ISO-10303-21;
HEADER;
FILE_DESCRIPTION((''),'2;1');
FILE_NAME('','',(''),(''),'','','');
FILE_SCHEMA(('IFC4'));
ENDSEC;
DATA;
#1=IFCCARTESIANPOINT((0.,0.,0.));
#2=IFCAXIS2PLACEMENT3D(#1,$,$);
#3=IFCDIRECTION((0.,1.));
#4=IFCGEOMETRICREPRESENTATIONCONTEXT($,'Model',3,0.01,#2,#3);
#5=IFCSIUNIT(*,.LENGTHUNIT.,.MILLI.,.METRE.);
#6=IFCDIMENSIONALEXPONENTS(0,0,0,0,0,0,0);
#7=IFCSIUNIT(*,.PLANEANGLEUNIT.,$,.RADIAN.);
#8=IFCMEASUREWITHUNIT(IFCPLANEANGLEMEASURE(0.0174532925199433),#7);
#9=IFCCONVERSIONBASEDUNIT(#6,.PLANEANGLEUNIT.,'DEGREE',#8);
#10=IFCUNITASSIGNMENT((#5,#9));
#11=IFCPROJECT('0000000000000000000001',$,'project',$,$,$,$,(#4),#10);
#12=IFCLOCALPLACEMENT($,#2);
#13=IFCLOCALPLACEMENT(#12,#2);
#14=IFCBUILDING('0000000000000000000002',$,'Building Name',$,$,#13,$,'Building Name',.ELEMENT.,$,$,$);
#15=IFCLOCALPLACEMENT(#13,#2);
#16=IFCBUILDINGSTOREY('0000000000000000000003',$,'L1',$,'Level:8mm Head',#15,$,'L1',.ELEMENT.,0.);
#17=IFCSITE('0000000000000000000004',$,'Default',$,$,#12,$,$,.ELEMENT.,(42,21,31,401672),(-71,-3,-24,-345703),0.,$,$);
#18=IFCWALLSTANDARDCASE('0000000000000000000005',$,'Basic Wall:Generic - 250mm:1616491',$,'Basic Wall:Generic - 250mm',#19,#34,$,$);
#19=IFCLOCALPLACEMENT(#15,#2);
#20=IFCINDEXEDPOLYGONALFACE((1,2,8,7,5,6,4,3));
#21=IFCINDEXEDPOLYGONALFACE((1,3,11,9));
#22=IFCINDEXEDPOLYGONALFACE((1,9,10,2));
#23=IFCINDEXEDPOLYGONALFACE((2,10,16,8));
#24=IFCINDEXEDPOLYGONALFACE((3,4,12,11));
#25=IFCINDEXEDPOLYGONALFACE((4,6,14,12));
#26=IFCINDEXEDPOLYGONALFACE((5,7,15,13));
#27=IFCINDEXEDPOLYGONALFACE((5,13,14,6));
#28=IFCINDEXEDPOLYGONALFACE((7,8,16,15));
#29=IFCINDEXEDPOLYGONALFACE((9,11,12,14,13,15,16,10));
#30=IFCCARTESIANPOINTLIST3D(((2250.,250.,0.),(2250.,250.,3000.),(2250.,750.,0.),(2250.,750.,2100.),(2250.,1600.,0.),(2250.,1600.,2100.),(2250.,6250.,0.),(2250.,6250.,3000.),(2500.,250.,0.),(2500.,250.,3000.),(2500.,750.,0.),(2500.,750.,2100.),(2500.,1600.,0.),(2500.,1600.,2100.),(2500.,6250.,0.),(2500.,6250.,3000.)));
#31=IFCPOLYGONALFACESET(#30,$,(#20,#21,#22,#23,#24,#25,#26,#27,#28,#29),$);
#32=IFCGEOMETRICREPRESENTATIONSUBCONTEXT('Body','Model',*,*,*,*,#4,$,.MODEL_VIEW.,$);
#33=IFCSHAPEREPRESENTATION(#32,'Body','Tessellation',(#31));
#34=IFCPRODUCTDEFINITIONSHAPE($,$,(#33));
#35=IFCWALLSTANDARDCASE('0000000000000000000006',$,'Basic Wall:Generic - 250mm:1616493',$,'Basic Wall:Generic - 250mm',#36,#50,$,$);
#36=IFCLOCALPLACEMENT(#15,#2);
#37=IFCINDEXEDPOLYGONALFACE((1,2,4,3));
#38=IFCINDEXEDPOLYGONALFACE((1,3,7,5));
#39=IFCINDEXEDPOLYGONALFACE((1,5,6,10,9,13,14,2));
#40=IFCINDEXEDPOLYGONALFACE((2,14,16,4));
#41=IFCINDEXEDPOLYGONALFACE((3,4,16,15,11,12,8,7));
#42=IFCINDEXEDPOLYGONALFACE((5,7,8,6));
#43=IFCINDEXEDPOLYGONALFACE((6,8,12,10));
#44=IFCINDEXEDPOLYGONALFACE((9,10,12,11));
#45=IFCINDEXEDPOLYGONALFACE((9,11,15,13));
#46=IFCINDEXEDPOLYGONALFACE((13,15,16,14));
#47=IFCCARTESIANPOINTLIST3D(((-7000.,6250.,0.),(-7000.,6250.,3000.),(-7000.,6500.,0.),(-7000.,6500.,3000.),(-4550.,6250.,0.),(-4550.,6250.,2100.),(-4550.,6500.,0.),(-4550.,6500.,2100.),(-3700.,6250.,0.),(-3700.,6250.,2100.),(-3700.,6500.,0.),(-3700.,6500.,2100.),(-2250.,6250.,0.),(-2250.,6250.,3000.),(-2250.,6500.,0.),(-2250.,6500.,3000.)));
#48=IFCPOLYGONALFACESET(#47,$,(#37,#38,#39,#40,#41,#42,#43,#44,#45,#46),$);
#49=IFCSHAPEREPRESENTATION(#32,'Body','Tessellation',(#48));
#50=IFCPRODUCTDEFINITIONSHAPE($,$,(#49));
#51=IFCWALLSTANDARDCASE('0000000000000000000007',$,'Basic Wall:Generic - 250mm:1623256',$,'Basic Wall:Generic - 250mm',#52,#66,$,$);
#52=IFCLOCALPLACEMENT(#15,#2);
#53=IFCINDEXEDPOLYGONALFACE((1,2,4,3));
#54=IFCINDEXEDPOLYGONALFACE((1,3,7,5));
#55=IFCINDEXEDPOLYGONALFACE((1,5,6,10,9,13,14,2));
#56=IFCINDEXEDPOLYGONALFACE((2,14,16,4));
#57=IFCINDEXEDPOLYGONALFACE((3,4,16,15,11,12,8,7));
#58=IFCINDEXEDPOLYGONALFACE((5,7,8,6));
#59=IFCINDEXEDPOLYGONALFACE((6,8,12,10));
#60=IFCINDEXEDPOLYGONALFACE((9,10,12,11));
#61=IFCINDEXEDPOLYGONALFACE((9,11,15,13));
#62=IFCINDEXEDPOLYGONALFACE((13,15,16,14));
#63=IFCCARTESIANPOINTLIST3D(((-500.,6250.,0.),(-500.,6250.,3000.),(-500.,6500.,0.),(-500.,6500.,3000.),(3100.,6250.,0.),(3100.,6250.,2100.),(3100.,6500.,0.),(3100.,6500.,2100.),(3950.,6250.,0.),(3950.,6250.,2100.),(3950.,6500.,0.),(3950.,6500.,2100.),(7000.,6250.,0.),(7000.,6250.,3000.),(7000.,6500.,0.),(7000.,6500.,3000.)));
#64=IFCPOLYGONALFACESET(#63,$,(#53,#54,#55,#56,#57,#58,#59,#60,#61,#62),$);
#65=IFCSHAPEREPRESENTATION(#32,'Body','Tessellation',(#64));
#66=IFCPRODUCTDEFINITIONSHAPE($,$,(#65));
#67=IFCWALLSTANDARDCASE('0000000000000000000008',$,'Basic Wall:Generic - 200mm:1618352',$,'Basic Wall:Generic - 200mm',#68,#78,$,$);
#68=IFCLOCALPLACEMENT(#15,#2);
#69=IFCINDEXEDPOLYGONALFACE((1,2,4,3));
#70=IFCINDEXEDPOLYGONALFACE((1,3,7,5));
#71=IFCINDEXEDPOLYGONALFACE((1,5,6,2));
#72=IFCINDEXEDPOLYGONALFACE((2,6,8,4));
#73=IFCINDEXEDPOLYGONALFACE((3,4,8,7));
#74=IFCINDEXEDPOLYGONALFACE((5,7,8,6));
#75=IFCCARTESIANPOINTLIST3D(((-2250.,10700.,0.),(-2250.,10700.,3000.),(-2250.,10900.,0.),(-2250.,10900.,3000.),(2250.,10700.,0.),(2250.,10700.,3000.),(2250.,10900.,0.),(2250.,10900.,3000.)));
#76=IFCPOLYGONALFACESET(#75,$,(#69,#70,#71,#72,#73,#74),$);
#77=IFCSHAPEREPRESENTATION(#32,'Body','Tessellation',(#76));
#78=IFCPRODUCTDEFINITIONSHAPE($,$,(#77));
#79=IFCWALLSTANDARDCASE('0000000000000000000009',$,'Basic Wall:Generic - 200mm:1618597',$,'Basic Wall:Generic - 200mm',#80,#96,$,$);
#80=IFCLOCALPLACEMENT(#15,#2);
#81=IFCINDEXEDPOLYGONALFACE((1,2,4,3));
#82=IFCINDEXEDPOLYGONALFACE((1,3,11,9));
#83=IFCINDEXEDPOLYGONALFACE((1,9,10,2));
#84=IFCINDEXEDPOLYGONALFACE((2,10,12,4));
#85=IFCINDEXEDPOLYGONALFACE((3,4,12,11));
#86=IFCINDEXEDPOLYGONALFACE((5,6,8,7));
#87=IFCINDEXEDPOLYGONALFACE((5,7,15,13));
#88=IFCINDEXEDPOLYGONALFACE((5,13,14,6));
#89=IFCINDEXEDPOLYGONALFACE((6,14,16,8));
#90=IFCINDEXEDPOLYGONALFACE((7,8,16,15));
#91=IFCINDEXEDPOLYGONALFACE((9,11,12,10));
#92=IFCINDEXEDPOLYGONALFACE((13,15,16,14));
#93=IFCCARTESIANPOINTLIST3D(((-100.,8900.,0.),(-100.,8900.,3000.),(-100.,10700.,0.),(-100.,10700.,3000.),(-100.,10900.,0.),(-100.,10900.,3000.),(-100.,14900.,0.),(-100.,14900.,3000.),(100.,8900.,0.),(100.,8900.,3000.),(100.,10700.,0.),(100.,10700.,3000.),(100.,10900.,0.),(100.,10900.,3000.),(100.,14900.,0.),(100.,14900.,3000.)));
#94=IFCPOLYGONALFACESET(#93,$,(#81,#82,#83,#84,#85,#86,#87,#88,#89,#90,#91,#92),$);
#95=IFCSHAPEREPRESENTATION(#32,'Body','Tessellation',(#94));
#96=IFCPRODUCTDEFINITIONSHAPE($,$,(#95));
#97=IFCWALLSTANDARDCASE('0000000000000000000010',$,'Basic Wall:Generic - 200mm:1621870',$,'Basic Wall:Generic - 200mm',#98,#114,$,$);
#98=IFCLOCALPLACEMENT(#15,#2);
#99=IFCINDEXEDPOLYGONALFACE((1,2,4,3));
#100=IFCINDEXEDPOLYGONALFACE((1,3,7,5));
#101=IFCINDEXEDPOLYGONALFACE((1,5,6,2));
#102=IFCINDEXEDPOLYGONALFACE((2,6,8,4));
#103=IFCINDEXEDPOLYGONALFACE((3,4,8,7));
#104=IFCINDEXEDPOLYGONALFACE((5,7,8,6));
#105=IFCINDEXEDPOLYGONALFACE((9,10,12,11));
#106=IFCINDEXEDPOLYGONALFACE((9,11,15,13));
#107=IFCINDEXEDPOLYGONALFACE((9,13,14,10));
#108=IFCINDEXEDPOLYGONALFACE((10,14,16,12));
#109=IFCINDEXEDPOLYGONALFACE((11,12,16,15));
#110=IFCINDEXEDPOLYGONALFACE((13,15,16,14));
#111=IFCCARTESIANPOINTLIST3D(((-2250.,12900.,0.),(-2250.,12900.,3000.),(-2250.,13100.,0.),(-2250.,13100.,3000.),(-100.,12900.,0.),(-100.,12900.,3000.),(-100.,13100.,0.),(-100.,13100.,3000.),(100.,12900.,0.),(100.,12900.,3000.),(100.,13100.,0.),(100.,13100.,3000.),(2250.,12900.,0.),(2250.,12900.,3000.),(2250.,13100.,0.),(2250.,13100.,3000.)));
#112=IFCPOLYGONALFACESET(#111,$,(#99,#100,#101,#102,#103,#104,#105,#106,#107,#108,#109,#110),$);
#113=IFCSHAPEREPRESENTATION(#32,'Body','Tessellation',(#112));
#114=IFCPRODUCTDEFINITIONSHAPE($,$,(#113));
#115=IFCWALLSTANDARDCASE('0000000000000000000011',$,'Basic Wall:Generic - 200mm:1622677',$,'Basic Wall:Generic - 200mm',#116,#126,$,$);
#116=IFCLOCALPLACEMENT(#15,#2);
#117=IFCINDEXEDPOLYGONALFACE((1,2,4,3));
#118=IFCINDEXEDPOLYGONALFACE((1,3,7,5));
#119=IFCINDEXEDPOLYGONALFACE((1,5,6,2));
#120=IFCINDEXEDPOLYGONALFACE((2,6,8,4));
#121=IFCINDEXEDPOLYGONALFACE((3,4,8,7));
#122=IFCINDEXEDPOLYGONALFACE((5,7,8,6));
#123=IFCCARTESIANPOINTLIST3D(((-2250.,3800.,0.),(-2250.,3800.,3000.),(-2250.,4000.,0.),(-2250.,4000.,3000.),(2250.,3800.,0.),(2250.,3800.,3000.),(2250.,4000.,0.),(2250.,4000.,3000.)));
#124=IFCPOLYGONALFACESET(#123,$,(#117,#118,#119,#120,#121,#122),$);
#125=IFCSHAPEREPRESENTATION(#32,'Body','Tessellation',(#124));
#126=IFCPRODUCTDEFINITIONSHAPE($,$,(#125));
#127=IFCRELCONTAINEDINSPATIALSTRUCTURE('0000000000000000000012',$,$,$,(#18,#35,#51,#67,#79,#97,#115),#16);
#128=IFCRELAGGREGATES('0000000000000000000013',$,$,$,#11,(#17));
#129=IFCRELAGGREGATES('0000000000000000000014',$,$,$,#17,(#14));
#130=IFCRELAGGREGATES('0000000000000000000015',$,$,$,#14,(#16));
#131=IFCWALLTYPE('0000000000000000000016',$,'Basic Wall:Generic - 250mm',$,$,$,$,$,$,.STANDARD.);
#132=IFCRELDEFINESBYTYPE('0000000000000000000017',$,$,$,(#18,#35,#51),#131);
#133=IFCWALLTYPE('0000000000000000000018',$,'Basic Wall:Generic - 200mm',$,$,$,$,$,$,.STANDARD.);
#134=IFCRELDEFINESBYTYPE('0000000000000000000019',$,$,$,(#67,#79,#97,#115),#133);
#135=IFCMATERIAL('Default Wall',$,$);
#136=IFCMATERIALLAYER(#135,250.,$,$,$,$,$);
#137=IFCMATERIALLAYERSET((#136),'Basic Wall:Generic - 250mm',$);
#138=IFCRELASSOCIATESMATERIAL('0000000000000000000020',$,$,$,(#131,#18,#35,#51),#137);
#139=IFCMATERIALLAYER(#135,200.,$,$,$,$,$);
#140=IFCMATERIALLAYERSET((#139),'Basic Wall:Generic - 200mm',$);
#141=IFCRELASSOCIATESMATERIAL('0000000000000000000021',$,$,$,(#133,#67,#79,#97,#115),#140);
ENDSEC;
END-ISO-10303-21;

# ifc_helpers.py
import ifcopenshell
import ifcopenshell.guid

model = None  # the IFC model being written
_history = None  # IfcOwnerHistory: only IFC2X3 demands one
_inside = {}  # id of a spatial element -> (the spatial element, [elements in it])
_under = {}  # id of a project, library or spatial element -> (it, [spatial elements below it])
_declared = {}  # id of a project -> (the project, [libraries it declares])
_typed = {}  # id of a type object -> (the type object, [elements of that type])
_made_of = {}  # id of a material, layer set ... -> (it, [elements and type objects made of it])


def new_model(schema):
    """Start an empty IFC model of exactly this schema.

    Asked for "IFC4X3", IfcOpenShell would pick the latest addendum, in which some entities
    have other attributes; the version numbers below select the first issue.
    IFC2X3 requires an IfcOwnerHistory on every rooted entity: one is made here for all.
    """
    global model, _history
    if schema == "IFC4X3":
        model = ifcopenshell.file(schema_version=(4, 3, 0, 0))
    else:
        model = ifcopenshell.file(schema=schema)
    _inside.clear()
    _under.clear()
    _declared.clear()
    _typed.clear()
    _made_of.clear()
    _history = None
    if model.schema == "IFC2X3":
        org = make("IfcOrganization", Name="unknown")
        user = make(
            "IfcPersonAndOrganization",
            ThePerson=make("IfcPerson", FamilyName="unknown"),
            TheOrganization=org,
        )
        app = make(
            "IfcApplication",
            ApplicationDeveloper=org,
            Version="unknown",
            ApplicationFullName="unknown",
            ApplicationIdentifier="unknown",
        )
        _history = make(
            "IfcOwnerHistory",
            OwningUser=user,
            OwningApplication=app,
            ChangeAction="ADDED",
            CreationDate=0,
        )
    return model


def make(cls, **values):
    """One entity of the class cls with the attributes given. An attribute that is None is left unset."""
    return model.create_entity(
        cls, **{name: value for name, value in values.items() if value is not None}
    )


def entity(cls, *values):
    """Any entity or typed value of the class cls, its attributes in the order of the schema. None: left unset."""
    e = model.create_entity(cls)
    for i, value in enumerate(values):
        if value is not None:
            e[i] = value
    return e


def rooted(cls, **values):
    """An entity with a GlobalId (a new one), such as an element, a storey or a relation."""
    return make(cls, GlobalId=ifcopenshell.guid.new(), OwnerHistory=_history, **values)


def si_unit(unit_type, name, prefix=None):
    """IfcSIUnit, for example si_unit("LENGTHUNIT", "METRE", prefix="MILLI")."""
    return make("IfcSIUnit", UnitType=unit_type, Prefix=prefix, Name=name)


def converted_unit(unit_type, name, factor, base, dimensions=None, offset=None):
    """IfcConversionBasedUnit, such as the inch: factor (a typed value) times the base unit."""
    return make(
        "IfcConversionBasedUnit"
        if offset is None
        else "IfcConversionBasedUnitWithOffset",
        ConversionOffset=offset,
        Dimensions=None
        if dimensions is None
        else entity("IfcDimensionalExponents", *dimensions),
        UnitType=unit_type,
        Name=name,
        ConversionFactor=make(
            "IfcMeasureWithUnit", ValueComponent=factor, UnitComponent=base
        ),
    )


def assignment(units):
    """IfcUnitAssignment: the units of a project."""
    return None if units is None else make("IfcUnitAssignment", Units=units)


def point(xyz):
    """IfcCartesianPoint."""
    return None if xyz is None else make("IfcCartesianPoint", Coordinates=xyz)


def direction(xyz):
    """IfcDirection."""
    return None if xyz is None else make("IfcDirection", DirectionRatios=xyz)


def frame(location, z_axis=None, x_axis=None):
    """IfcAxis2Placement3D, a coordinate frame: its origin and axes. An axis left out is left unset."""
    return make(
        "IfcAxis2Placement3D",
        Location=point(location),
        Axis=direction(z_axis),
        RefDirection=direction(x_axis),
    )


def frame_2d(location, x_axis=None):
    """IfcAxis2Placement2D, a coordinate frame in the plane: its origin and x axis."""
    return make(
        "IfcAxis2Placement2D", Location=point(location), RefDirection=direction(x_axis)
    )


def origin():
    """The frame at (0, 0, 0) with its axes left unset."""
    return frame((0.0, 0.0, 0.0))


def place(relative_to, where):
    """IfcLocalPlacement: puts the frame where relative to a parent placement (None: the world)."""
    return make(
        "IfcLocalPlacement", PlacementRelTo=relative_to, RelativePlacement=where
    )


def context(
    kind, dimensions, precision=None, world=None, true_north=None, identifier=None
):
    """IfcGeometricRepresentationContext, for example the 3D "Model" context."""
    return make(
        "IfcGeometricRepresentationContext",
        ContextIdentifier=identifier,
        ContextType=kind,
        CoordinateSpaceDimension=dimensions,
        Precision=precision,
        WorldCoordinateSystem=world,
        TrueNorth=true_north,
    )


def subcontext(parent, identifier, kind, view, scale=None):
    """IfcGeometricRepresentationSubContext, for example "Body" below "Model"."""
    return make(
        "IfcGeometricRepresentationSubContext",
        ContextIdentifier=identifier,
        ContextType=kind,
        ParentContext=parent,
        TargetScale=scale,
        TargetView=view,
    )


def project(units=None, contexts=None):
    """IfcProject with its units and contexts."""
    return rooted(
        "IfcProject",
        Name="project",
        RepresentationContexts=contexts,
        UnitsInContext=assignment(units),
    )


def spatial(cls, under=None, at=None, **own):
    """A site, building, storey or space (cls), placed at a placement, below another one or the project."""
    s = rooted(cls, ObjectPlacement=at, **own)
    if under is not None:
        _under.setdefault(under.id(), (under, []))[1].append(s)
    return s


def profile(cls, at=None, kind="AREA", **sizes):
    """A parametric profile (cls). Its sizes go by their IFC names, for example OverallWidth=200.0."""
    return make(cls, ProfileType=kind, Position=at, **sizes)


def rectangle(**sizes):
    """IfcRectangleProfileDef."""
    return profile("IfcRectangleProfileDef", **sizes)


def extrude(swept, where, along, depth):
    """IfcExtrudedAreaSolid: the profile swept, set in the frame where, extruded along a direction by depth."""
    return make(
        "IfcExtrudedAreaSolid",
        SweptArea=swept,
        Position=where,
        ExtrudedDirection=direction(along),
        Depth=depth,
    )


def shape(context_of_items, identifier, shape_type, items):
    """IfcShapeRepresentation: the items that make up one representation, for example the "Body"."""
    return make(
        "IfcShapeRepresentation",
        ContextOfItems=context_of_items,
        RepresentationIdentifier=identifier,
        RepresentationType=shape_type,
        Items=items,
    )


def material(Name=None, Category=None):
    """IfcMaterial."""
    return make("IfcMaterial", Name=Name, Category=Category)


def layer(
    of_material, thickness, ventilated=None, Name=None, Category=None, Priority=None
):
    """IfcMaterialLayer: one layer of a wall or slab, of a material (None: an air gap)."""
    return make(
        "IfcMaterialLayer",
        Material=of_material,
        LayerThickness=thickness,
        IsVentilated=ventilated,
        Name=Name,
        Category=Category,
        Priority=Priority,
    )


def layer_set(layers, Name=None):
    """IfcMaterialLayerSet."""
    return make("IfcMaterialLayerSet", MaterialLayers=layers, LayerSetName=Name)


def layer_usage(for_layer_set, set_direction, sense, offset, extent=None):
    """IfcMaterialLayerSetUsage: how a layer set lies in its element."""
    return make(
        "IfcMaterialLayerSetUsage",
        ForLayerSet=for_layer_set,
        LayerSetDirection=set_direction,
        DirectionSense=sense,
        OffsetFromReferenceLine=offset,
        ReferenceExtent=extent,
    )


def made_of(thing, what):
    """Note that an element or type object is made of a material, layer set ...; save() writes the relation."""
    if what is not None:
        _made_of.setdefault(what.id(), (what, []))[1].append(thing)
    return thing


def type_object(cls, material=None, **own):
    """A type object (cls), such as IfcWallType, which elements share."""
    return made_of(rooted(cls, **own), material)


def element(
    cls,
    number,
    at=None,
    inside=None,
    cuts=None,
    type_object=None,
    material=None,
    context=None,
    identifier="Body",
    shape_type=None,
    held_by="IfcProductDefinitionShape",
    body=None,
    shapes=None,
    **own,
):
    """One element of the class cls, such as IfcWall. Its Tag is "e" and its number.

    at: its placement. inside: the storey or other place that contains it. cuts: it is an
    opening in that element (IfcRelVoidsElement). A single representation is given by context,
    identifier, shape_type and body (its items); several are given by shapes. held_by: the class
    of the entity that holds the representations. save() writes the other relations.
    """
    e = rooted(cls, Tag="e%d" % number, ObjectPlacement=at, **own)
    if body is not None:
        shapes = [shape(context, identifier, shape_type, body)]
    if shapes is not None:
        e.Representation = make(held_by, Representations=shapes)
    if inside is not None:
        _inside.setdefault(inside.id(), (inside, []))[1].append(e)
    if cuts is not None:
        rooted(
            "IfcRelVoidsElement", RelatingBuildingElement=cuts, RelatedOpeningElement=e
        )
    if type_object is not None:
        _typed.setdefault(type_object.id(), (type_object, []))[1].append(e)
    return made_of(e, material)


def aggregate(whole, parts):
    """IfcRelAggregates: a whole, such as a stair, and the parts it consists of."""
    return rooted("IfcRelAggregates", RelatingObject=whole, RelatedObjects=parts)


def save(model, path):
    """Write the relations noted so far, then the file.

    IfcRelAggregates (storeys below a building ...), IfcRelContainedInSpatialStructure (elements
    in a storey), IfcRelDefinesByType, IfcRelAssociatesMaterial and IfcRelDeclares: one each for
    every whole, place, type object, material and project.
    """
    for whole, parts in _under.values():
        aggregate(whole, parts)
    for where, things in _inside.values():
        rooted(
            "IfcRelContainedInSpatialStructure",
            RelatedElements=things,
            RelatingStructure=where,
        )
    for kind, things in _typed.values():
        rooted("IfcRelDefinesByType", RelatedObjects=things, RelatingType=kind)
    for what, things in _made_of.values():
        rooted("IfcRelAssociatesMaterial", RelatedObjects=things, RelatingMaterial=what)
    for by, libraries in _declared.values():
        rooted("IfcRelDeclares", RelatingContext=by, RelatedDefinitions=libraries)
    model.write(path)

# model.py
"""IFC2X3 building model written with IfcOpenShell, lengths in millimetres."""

from ifc_helpers import new_model, entity, si_unit, converted_unit, direction, frame, frame_2d, origin, place, context, subcontext, project, spatial, rectangle, extrude, material, layer, layer_set, layer_usage, type_object, element, save


model = new_model("IFC2X3")

# Units and contexts
model_context = context("Model", 3, precision=0.01, world=origin(), true_north=direction((0.0, 1.0)))
body_context = subcontext(model_context, "Body", "Model", "MODEL_VIEW")
ifc_project = project(units=[si_unit("LENGTHUNIT", "METRE", prefix="MILLI"), converted_unit("PLANEANGLEUNIT", "DEGREE", entity("IfcPlaneAngleMeasure", 0.0174532925199433), si_unit("PLANEANGLEUNIT", "RADIAN"), dimensions=[0, 0, 0, 0, 0, 0, 0])], contexts=[model_context])

# Site, building, storey
site_placement = place(None, origin())
site = spatial("IfcSite", under=ifc_project, at=site_placement, Name="Default", CompositionType="ELEMENT", RefLatitude=(42, 21, 31, 401672), RefLongitude=(-71, -3, -24, -345703), RefElevation=0.0)
building_placement = place(site_placement, origin())
building = spatial("IfcBuilding", under=site, at=building_placement, Name="Building Name", LongName="Building Name", CompositionType="ELEMENT")
storey_placement = place(building_placement, origin())
storey = spatial("IfcBuildingStorey", under=building, at=storey_placement, Name="L1", ObjectType="Level:8mm Head", LongName="L1", CompositionType="ELEMENT", Elevation=0.0)

# Shared definitions
ifc_material = material(Name="Default Wall")
ifc_layer_1 = layer(ifc_material, 250.0)
ifc_layer_set_1 = layer_set([ifc_layer_1], Name="Basic Wall:Generic - 250mm")
wall_type_1 = type_object("IfcWallType", Name="Basic Wall:Generic - 250mm", PredefinedType="STANDARD", material=ifc_layer_set_1)

# Walls, openings
ifc_layer_usage_1 = layer_usage(ifc_layer_set_1, "AXIS2", "NEGATIVE", 125.0)
wall_1_placement = place(storey_placement, frame((2375.0, 250.0, 0.0), z_axis=(0.0, 0.0, 1.0), x_axis=(0.0, 1.0, 0.0)))
wall_1 = element("IfcWallStandardCase", 1, at=wall_1_placement, inside=storey, type_object=wall_type_1, material=ifc_layer_usage_1, Name="Basic Wall:Generic - 250mm:1616491", ObjectType="Basic Wall:Generic - 250mm", context=body_context, shape_type="SweptSolid", body=[
    extrude(rectangle(XDim=6000.0, YDim=250.0, at=frame_2d((3000.0, 0.0), x_axis=(1.0, 0.0))), origin(), (0.0, 0.0, 1.0), 3000.0),
])
opening_1_placement = place(wall_1_placement, frame((500.0, -125.0, 0.0)))
element("IfcOpeningElement", 2, at=opening_1_placement, cuts=wall_1, ObjectType="Opening", context=body_context, shape_type="SweptSolid", body=[
    extrude(rectangle(XDim=2100.0, YDim=850.0, at=frame_2d((1050.0, 425.0), x_axis=(1.0, 0.0))), frame((0.0, 0.0, 0.0), z_axis=(0.0, 1.0, 0.0), x_axis=(0.0, 0.0, 1.0)), (0.0, 0.0, 1.0), 250.0),
])
ifc_layer_usage_2 = layer_usage(ifc_layer_set_1, "AXIS2", "NEGATIVE", 125.0)
wall_2_placement = place(storey_placement, frame((-7000.0, 6375.0, 0.0)))
wall_2 = element("IfcWallStandardCase", 3, at=wall_2_placement, inside=storey, type_object=wall_type_1, material=ifc_layer_usage_2, Name="Basic Wall:Generic - 250mm:1616493", ObjectType="Basic Wall:Generic - 250mm", context=body_context, shape_type="SweptSolid", body=[
    extrude(rectangle(XDim=4750.0, YDim=250.0, at=frame_2d((2375.0, 0.0), x_axis=(1.0, 0.0))), origin(), (0.0, 0.0, 1.0), 3000.0),
])
opening_2_placement = place(wall_2_placement, frame((3300.0, 125.0, 0.0)))
element("IfcOpeningElement", 4, at=opening_2_placement, cuts=wall_2, ObjectType="Opening", context=body_context, shape_type="SweptSolid", body=[
    extrude(rectangle(XDim=2100.0, YDim=850.0, at=frame_2d((1050.0, 425.0), x_axis=(1.0, 0.0))), frame((0.0, 0.0, 0.0), z_axis=(0.0, -1.0, 0.0), x_axis=(0.0, 0.0, 1.0)), (0.0, 0.0, 1.0), 250.0),
])

# Wall, openings
ifc_layer_usage_3 = layer_usage(ifc_layer_set_1, "AXIS2", "NEGATIVE", 125.0)
wall_3_placement = place(storey_placement, frame((-500.0, 6375.0, 0.0)))
wall_3 = element("IfcWallStandardCase", 5, at=wall_3_placement, inside=storey, type_object=wall_type_1, material=ifc_layer_usage_3, Name="Basic Wall:Generic - 250mm:1623256", ObjectType="Basic Wall:Generic - 250mm", context=body_context, shape_type="SweptSolid", body=[
    extrude(rectangle(XDim=7500.0, YDim=250.0, at=frame_2d((3750.0, 0.0), x_axis=(1.0, 0.0))), origin(), (0.0, 0.0, 1.0), 3000.0),
])
opening_3_placement = place(wall_3_placement, frame((4450.0, 125.0, 0.0)))
element("IfcOpeningElement", 6, at=opening_3_placement, cuts=wall_3, ObjectType="Opening", context=body_context, shape_type="SweptSolid", body=[
    extrude(rectangle(XDim=2100.0, YDim=850.0, at=frame_2d((1050.0, 425.0), x_axis=(1.0, 0.0))), frame((0.0, 0.0, 0.0), z_axis=(0.0, -1.0, 0.0), x_axis=(0.0, 0.0, 1.0)), (0.0, 0.0, 1.0), 250.0),
])
opening_4_placement = place(wall_3_placement, frame((500.0, -6375.0, 0.0)))
element("IfcOpeningElement", 7, at=opening_4_placement, cuts=wall_3, ObjectType="Opening", context=body_context, shape_type="SweptSolid", body=[
    extrude(rectangle(XDim=2100.0, YDim=850.0, at=frame_2d((0.0, 0.0), x_axis=(1.0, 0.0))), frame((3525.0, 4976.0, 1050.0), z_axis=(0.0, 1.0, 0.0), x_axis=(0.0, 0.0, 1.0)), (0.0, 0.0, 1.0), 3048.0),
])

# Wall
ifc_layer_2 = layer(ifc_material, 200.0)
ifc_layer_set_2 = layer_set([ifc_layer_2], Name="Basic Wall:Generic - 200mm")
ifc_layer_usage_4 = layer_usage(ifc_layer_set_2, "AXIS2", "NEGATIVE", 100.0)
wall_type_2 = type_object("IfcWallType", Name="Basic Wall:Generic - 200mm", PredefinedType="STANDARD", material=ifc_layer_set_2)
wall_4_placement = place(storey_placement, frame((-2250.0, 10800.0, 0.0)))
element("IfcWallStandardCase", 8, at=wall_4_placement, inside=storey, type_object=wall_type_2, material=ifc_layer_usage_4, Name="Basic Wall:Generic - 200mm:1618352", ObjectType="Basic Wall:Generic - 200mm", context=body_context, shape_type="SweptSolid", body=[
    extrude(rectangle(XDim=4500.0, YDim=200.0, at=frame_2d((2250.0, 0.0), x_axis=(-1.0, 0.0))), origin(), (0.0, 0.0, 1.0), 3000.0),
])

# Walls, openings
ifc_layer_usage_5 = layer_usage(ifc_layer_set_2, "AXIS2", "NEGATIVE", 100.0)
wall_5_placement = place(storey_placement, frame((0.0, 8900.0, 0.0), z_axis=(0.0, 0.0, 1.0), x_axis=(0.0, 1.0, 0.0)))
wall_5 = element("IfcWallStandardCase", 9, at=wall_5_placement, inside=storey, type_object=wall_type_2, material=ifc_layer_usage_5, Name="Basic Wall:Generic - 200mm:1618597", ObjectType="Basic Wall:Generic - 200mm", context=body_context, shape_type="SweptSolid", body=[
    extrude(rectangle(XDim=6000.0, YDim=200.0, at=frame_2d((3000.0, 0.0), x_axis=(-1.0, 0.0))), origin(), (0.0, 0.0, 1.0), 3000.0),
])
opening_5_placement = place(storey_placement, frame((0.0, 8900.0, 0.0), z_axis=(0.0, 0.0, 1.0), x_axis=(0.0, 1.0, 0.0)))
element("IfcOpeningElement", 10, at=opening_5_placement, cuts=wall_5, ObjectType="Opening", context=body_context, shape_type="SweptSolid", body=[
    extrude(rectangle(XDim=3000.0, YDim=200.0, at=frame_2d((0.0, 0.0), x_axis=(1.0, 0.0))), frame((1800.0, 0.0, 1500.0), z_axis=(1.0, 0.0, 0.0), x_axis=(0.0, 0.0, -1.0)), (0.0, 0.0, 1.0), 200.0),
])
ifc_layer_usage_6 = layer_usage(ifc_layer_set_2, "AXIS2", "NEGATIVE", 100.0)
wall_6_placement = place(storey_placement, frame((-2250.0, 13000.0, 0.0)))
wall_6 = element("IfcWallStandardCase", 11, at=wall_6_placement, inside=storey, type_object=wall_type_2, material=ifc_layer_usage_6, Name="Basic Wall:Generic - 200mm:1621870", ObjectType="Basic Wall:Generic - 200mm", context=body_context, shape_type="SweptSolid", body=[
    extrude(rectangle(XDim=4500.0, YDim=200.0, at=frame_2d((2250.0, 0.0), x_axis=(-1.0, 0.0))), origin(), (0.0, 0.0, 1.0), 3000.0),
])
opening_6_placement = place(storey_placement, frame((-2250.0, 13000.0, 0.0)))
element("IfcOpeningElement", 12, at=opening_6_placement, cuts=wall_6, ObjectType="Opening", context=body_context, shape_type="SweptSolid", body=[
    extrude(rectangle(XDim=3000.0, YDim=200.0, at=frame_2d((0.0, 0.0), x_axis=(1.0, 0.0))), frame((2150.0, 0.0, 1500.0), z_axis=(1.0, 0.0, 0.0), x_axis=(0.0, 0.0, -1.0)), (0.0, 0.0, 1.0), 200.0),
])

# Wall
ifc_layer_usage_7 = layer_usage(ifc_layer_set_2, "AXIS2", "NEGATIVE", 100.0)
wall_7_placement = place(storey_placement, frame((-2250.0, 3900.0, 0.0)))
element("IfcWallStandardCase", 13, at=wall_7_placement, inside=storey, type_object=wall_type_2, material=ifc_layer_usage_7, Name="Basic Wall:Generic - 200mm:1622677", ObjectType="Basic Wall:Generic - 200mm", context=body_context, shape_type="SweptSolid", body=[
    extrude(rectangle(XDim=4500.0, YDim=200.0, at=frame_2d((2250.0, 0.0), x_axis=(-1.0, 0.0))), origin(), (0.0, 0.0, 1.0), 3000.0),
])

save(model, "model.ifc")
